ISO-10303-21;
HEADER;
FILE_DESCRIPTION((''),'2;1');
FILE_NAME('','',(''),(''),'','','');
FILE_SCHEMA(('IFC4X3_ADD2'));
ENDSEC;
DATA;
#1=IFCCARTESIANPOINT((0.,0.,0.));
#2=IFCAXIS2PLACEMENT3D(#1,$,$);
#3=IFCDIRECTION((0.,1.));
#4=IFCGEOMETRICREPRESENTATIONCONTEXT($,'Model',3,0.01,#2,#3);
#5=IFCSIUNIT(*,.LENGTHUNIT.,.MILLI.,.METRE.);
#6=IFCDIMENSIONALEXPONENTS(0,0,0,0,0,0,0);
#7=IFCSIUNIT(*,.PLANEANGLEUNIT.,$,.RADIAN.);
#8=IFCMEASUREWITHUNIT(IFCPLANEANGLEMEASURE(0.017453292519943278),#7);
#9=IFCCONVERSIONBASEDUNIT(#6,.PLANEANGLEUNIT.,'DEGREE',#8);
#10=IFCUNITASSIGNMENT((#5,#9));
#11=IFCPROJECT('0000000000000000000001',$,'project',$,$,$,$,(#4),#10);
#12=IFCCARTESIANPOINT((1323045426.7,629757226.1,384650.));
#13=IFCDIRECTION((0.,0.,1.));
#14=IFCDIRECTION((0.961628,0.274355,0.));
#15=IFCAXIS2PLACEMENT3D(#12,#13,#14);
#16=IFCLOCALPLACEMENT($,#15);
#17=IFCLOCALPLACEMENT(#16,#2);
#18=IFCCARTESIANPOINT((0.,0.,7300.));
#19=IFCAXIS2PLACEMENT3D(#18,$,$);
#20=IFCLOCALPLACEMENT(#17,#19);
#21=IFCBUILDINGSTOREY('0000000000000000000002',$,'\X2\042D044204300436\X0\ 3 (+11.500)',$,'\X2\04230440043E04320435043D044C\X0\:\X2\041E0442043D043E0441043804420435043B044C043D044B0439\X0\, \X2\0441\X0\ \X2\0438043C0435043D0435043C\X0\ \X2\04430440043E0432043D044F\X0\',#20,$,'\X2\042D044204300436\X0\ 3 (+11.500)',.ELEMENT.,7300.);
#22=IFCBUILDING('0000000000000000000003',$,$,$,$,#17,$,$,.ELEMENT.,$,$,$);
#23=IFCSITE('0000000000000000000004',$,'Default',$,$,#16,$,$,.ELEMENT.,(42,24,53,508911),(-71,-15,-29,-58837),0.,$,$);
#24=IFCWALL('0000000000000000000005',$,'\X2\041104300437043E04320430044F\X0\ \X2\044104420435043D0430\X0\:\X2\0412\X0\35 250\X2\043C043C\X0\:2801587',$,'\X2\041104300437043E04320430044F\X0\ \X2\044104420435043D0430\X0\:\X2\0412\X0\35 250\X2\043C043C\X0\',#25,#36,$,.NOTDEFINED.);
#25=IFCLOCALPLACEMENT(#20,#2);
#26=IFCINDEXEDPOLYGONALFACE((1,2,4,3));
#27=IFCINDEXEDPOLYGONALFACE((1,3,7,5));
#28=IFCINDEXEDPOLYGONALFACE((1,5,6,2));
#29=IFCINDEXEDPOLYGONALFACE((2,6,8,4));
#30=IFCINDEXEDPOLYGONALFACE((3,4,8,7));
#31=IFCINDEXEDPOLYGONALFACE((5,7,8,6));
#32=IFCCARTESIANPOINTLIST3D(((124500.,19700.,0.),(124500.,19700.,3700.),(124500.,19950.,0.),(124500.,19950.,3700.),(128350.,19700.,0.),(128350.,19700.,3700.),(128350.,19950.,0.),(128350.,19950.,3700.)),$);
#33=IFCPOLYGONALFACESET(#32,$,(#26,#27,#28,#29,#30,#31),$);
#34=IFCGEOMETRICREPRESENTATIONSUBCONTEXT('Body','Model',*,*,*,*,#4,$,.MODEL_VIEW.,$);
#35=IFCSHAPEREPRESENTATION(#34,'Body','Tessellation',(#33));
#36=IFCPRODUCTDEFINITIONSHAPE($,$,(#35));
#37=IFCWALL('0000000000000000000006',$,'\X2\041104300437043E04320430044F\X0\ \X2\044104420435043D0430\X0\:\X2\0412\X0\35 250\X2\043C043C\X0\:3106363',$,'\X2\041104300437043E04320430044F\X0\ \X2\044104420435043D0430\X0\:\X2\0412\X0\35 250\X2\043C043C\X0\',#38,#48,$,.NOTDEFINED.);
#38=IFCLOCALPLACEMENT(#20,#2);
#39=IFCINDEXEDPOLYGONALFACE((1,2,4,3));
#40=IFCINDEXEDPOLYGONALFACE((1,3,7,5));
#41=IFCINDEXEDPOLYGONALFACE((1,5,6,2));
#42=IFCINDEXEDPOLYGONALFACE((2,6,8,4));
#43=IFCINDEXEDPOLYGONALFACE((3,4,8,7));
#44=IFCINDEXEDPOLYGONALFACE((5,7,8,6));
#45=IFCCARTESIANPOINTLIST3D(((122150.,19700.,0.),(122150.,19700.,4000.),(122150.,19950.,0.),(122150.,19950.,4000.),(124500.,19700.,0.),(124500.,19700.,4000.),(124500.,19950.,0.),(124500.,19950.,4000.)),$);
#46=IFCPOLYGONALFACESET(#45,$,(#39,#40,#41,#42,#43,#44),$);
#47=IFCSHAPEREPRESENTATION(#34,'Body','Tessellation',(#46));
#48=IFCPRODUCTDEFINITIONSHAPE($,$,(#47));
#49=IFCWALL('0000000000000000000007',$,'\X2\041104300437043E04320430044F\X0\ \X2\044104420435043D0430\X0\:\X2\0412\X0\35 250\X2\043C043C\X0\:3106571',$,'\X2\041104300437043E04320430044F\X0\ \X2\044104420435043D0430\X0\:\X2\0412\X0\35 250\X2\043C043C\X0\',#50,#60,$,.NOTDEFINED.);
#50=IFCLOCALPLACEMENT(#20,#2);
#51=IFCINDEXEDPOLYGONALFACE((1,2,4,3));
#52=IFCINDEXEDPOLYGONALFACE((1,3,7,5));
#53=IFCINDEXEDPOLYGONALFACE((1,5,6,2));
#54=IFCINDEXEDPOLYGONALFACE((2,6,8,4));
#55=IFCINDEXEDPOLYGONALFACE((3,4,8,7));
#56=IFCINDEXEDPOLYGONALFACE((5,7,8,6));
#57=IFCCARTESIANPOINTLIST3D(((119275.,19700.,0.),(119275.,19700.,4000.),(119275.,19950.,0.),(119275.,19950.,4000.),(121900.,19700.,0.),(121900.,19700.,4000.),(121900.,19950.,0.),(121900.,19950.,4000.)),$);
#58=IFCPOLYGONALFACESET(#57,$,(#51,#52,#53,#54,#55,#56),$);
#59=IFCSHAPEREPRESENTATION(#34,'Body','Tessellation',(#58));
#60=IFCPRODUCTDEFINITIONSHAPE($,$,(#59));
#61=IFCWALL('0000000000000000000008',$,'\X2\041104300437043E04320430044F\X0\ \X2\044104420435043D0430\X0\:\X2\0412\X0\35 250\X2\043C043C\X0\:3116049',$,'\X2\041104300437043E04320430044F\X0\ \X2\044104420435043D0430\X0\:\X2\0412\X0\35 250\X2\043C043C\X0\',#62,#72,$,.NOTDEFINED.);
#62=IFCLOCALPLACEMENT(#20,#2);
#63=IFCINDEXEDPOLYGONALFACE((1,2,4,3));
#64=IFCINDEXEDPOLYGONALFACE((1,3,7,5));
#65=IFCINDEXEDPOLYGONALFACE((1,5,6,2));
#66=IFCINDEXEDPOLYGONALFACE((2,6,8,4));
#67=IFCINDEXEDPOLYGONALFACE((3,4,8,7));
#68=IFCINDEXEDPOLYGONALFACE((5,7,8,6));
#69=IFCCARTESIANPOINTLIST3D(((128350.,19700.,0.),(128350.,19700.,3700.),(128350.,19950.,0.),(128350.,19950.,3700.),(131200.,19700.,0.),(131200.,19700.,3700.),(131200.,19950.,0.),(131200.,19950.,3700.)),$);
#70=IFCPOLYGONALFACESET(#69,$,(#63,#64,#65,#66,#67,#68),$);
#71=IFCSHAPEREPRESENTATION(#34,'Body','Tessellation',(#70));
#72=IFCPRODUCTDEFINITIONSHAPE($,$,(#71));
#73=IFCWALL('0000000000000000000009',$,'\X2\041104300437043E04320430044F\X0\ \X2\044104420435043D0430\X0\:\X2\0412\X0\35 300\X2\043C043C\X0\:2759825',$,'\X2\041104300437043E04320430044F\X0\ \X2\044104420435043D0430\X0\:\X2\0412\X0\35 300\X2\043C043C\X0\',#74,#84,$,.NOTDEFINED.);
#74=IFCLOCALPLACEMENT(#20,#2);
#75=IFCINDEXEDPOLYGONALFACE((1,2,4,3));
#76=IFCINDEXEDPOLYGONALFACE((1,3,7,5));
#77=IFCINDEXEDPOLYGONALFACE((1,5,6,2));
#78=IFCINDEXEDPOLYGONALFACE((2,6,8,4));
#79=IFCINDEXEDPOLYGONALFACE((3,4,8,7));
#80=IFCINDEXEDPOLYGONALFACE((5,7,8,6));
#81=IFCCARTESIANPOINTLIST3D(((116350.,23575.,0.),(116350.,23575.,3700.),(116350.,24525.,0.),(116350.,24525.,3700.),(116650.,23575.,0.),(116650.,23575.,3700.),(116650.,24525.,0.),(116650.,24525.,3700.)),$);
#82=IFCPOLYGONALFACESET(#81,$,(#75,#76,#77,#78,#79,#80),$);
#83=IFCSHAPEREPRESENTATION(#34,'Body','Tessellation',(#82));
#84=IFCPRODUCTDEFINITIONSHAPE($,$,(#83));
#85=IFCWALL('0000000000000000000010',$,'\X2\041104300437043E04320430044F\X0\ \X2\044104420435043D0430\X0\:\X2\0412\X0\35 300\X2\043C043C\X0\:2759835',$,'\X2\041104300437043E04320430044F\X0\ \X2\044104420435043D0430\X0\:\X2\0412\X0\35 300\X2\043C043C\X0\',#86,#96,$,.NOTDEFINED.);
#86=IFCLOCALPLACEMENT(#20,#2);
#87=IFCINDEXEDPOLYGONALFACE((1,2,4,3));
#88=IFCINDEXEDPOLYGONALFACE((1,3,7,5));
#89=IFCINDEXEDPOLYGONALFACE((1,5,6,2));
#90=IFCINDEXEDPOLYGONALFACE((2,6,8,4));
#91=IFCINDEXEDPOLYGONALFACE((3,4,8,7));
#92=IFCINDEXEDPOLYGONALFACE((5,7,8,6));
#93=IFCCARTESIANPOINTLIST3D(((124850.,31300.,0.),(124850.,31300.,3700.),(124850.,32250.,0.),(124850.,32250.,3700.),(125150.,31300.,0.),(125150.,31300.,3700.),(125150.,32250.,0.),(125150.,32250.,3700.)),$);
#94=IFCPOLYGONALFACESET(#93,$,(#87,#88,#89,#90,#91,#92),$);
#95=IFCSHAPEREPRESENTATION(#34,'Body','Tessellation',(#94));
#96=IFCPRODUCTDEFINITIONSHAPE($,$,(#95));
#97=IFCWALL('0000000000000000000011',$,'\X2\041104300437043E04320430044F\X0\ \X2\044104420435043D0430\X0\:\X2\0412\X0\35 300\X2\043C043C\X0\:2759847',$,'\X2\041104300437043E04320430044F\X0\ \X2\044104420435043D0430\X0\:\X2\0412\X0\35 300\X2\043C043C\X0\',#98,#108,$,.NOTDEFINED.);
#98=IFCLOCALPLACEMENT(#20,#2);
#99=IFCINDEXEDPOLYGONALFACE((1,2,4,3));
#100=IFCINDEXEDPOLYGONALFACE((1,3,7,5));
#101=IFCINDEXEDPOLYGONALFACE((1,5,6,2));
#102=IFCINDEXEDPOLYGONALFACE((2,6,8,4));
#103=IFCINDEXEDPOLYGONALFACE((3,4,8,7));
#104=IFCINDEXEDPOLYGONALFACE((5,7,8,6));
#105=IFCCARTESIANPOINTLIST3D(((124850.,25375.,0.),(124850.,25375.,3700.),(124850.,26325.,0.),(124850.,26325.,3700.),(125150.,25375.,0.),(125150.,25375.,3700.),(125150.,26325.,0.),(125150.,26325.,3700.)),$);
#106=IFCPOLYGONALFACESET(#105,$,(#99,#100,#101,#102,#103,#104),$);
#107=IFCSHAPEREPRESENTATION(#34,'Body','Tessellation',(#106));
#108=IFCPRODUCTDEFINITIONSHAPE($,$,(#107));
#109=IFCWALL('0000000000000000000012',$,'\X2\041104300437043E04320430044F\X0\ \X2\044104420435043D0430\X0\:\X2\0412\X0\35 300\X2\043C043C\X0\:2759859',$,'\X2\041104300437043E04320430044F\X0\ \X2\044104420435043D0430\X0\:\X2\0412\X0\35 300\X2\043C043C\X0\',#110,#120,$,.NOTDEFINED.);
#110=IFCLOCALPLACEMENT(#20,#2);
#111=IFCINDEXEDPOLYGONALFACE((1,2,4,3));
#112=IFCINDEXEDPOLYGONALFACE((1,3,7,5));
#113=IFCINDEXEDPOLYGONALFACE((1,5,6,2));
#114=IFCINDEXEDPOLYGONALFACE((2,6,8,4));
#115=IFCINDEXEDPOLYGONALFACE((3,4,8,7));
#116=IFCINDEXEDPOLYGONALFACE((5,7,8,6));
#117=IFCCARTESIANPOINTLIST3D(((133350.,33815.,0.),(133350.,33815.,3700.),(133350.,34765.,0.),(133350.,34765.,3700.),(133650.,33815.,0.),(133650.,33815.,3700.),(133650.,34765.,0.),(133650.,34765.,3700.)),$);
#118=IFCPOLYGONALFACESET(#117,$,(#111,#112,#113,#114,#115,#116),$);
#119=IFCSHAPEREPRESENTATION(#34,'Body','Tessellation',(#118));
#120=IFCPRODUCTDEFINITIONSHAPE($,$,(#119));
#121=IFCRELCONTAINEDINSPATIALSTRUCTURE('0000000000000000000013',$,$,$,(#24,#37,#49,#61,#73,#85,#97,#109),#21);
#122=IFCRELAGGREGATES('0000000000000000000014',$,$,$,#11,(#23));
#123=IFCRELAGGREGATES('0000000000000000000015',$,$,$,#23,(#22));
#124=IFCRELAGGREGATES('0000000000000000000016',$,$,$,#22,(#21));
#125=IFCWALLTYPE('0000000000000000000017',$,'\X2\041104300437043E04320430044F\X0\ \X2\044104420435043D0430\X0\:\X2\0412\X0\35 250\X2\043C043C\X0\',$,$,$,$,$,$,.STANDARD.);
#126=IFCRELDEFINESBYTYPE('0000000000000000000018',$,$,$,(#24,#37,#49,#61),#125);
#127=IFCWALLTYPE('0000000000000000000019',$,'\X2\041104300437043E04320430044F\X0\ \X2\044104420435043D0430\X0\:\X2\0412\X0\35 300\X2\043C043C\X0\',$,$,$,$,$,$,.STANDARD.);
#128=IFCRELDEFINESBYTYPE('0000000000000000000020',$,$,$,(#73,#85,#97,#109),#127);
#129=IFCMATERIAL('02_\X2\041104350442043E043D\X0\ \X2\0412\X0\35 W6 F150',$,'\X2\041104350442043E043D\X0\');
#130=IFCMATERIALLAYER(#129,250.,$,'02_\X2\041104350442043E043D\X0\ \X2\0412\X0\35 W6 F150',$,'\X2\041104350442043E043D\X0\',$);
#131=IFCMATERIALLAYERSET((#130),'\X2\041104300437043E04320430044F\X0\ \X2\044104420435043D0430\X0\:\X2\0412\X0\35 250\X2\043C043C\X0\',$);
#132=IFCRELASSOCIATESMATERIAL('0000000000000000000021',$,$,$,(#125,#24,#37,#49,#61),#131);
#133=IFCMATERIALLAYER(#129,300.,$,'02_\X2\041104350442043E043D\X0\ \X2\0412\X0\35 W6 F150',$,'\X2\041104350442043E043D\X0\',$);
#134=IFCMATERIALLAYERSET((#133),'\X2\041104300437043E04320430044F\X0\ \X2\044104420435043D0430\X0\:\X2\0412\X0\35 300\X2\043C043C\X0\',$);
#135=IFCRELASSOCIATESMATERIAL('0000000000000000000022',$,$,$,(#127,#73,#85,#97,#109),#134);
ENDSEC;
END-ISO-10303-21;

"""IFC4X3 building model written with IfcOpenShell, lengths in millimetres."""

from ifc_helpers import new_model, entity, si_unit, converted_unit, direction, frame, frame_2d, origin, place, context, subcontext, project, spatial, rectangle, extrude, material, layer, layer_set, type_object, element, save


model = new_model("IFC4X3")

# Units and contexts
model_context = context("Model", 3, precision=0.01, world=origin(), true_north=direction((0.0, 1.0)))
body_context = subcontext(model_context, "Body", "Model", "MODEL_VIEW")
ifc_project = project(units=[si_unit("LENGTHUNIT", "METRE", prefix="MILLI"), converted_unit("PLANEANGLEUNIT", "DEGREE", entity("IfcPlaneAngleMeasure", 0.017453292519943278), si_unit("PLANEANGLEUNIT", "RADIAN"), dimensions=[0, 0, 0, 0, 0, 0, 0])], contexts=[model_context])

# Site, building, storey
site_placement = place(None, frame((1323045426.7, 629757226.1, 384650.0), z_axis=(0.0, 0.0, 1.0), x_axis=(0.961628, 0.274355, 0.0)))
site = spatial("IfcSite", under=ifc_project, at=site_placement, Name="Default", CompositionType="ELEMENT", RefLatitude=(42, 24, 53, 508911), RefLongitude=(-71, -15, -29, -58837), RefElevation=0.0)
building_placement = place(site_placement, origin())
building = spatial("IfcBuilding", under=site, at=building_placement, CompositionType="ELEMENT")
storey_placement = place(building_placement, frame((0.0, 0.0, 7300.0)))
storey = spatial("IfcBuildingStorey", under=building, at=storey_placement, Name="Этаж 3 (+11.500)", ObjectType="Уровень:Относительный, с именем уровня", LongName="Этаж 3 (+11.500)", CompositionType="ELEMENT", Elevation=7300.0)

# Shared definitions
ifc_material = material(Name="02_Бетон В35 W6 F150", Category="Бетон")
ifc_layer_1 = layer(ifc_material, 250.0, Name="02_Бетон В35 W6 F150", Category="Бетон")
ifc_layer_set_1 = layer_set([ifc_layer_1], Name="Базовая стена:В35 250мм")
wall_type_1 = type_object("IfcWallType", Name="Базовая стена:В35 250мм", PredefinedType="STANDARD", material=ifc_layer_set_1)

# Walls
wall_1_placement = place(storey_placement, frame((124500.0, 19825.0, 0.0)))
element("IfcWall", 1, at=wall_1_placement, inside=storey, type_object=wall_type_1, material=ifc_layer_set_1, Name="Базовая стена:В35 250мм:2801587", ObjectType="Базовая стена:В35 250мм", PredefinedType="NOTDEFINED", context=body_context, shape_type="SweptSolid", body=[
    extrude(rectangle(XDim=3850.0, YDim=250.0, at=frame_2d((1925.0, 0.0), x_axis=(-1.0, 0.0))), origin(), (0.0, 0.0, 1.0), 3700.0),
])
wall_2_placement = place(storey_placement, frame((122150.0, 19825.0, 0.0)))
element("IfcWall", 2, at=wall_2_placement, inside=storey, type_object=wall_type_1, material=ifc_layer_set_1, Name="Базовая стена:В35 250мм:3106363", ObjectType="Базовая стена:В35 250мм", PredefinedType="NOTDEFINED", context=body_context, shape_type="SweptSolid", body=[
    extrude(rectangle(XDim=2350.0, YDim=250.0, at=frame_2d((1175.0, 0.0), x_axis=(-1.0, 0.0))), origin(), (0.0, 0.0, 1.0), 4000.0),
])
wall_3_placement = place(storey_placement, frame((119275.0, 19825.0, 0.0)))
element("IfcWall", 3, at=wall_3_placement, inside=storey, type_object=wall_type_1, material=ifc_layer_set_1, Name="Базовая стена:В35 250мм:3106571", ObjectType="Базовая стена:В35 250мм", PredefinedType="NOTDEFINED", context=body_context, shape_type="SweptSolid", body=[
    extrude(rectangle(XDim=2625.0, YDim=250.0, at=frame_2d((1312.5, 0.0), x_axis=(-1.0, 0.0))), origin(), (0.0, 0.0, 1.0), 4000.0),
])
wall_4_placement = place(storey_placement, frame((128350.0, 19825.0, 0.0)))
element("IfcWall", 4, at=wall_4_placement, inside=storey, type_object=wall_type_1, material=ifc_layer_set_1, Name="Базовая стена:В35 250мм:3116049", ObjectType="Базовая стена:В35 250мм", PredefinedType="NOTDEFINED", context=body_context, shape_type="SweptSolid", body=[
    extrude(rectangle(XDim=2850.0, YDim=250.0, at=frame_2d((1425.0, 0.0), x_axis=(-1.0, 0.0))), origin(), (0.0, 0.0, 1.0), 3700.0),
])
ifc_layer_2 = layer(ifc_material, 300.0, Name="02_Бетон В35 W6 F150", Category="Бетон")
ifc_layer_set_2 = layer_set([ifc_layer_2], Name="Базовая стена:В35 300мм")
wall_type_2 = type_object("IfcWallType", Name="Базовая стена:В35 300мм", PredefinedType="STANDARD", material=ifc_layer_set_2)
for number, where, z_axis, x_axis, name in (
    (5, (116500.0, 23575.0, 0.0), (0.0, 0.0, 1.0), (0.0, 1.0, 0.0), "Базовая стена:В35 300мм:2759825"),
    (6, (125000.0, 31300.0, 0.0), (0.0, 0.0, 1.0), (0.0, 1.0, 0.0), "Базовая стена:В35 300мм:2759835"),
    (7, (125000.0, 25375.0, 0.0), (0.0, 0.0, 1.0), (0.0, 1.0, 0.0), "Базовая стена:В35 300мм:2759847"),
    (8, (133500.0, 33815.0, 0.0), (0.0, 0.0, 1.0), (0.0, 1.0, 0.0), "Базовая стена:В35 300мм:2759859"),
):
    element("IfcWall", number, at=place(storey_placement, frame(where, z_axis=z_axis, x_axis=x_axis)), inside=storey, type_object=wall_type_2, material=ifc_layer_set_2, Name=name, ObjectType="Базовая стена:В35 300мм", PredefinedType="NOTDEFINED", context=body_context, shape_type="SweptSolid", body=[
        extrude(rectangle(XDim=950.0, YDim=300.0, at=frame_2d((475.0, 0.0), x_axis=(-1.0, 0.0))), origin(), (0.0, 0.0, 1.0), 3700.0),
    ])

save(model, "model.ifc")
